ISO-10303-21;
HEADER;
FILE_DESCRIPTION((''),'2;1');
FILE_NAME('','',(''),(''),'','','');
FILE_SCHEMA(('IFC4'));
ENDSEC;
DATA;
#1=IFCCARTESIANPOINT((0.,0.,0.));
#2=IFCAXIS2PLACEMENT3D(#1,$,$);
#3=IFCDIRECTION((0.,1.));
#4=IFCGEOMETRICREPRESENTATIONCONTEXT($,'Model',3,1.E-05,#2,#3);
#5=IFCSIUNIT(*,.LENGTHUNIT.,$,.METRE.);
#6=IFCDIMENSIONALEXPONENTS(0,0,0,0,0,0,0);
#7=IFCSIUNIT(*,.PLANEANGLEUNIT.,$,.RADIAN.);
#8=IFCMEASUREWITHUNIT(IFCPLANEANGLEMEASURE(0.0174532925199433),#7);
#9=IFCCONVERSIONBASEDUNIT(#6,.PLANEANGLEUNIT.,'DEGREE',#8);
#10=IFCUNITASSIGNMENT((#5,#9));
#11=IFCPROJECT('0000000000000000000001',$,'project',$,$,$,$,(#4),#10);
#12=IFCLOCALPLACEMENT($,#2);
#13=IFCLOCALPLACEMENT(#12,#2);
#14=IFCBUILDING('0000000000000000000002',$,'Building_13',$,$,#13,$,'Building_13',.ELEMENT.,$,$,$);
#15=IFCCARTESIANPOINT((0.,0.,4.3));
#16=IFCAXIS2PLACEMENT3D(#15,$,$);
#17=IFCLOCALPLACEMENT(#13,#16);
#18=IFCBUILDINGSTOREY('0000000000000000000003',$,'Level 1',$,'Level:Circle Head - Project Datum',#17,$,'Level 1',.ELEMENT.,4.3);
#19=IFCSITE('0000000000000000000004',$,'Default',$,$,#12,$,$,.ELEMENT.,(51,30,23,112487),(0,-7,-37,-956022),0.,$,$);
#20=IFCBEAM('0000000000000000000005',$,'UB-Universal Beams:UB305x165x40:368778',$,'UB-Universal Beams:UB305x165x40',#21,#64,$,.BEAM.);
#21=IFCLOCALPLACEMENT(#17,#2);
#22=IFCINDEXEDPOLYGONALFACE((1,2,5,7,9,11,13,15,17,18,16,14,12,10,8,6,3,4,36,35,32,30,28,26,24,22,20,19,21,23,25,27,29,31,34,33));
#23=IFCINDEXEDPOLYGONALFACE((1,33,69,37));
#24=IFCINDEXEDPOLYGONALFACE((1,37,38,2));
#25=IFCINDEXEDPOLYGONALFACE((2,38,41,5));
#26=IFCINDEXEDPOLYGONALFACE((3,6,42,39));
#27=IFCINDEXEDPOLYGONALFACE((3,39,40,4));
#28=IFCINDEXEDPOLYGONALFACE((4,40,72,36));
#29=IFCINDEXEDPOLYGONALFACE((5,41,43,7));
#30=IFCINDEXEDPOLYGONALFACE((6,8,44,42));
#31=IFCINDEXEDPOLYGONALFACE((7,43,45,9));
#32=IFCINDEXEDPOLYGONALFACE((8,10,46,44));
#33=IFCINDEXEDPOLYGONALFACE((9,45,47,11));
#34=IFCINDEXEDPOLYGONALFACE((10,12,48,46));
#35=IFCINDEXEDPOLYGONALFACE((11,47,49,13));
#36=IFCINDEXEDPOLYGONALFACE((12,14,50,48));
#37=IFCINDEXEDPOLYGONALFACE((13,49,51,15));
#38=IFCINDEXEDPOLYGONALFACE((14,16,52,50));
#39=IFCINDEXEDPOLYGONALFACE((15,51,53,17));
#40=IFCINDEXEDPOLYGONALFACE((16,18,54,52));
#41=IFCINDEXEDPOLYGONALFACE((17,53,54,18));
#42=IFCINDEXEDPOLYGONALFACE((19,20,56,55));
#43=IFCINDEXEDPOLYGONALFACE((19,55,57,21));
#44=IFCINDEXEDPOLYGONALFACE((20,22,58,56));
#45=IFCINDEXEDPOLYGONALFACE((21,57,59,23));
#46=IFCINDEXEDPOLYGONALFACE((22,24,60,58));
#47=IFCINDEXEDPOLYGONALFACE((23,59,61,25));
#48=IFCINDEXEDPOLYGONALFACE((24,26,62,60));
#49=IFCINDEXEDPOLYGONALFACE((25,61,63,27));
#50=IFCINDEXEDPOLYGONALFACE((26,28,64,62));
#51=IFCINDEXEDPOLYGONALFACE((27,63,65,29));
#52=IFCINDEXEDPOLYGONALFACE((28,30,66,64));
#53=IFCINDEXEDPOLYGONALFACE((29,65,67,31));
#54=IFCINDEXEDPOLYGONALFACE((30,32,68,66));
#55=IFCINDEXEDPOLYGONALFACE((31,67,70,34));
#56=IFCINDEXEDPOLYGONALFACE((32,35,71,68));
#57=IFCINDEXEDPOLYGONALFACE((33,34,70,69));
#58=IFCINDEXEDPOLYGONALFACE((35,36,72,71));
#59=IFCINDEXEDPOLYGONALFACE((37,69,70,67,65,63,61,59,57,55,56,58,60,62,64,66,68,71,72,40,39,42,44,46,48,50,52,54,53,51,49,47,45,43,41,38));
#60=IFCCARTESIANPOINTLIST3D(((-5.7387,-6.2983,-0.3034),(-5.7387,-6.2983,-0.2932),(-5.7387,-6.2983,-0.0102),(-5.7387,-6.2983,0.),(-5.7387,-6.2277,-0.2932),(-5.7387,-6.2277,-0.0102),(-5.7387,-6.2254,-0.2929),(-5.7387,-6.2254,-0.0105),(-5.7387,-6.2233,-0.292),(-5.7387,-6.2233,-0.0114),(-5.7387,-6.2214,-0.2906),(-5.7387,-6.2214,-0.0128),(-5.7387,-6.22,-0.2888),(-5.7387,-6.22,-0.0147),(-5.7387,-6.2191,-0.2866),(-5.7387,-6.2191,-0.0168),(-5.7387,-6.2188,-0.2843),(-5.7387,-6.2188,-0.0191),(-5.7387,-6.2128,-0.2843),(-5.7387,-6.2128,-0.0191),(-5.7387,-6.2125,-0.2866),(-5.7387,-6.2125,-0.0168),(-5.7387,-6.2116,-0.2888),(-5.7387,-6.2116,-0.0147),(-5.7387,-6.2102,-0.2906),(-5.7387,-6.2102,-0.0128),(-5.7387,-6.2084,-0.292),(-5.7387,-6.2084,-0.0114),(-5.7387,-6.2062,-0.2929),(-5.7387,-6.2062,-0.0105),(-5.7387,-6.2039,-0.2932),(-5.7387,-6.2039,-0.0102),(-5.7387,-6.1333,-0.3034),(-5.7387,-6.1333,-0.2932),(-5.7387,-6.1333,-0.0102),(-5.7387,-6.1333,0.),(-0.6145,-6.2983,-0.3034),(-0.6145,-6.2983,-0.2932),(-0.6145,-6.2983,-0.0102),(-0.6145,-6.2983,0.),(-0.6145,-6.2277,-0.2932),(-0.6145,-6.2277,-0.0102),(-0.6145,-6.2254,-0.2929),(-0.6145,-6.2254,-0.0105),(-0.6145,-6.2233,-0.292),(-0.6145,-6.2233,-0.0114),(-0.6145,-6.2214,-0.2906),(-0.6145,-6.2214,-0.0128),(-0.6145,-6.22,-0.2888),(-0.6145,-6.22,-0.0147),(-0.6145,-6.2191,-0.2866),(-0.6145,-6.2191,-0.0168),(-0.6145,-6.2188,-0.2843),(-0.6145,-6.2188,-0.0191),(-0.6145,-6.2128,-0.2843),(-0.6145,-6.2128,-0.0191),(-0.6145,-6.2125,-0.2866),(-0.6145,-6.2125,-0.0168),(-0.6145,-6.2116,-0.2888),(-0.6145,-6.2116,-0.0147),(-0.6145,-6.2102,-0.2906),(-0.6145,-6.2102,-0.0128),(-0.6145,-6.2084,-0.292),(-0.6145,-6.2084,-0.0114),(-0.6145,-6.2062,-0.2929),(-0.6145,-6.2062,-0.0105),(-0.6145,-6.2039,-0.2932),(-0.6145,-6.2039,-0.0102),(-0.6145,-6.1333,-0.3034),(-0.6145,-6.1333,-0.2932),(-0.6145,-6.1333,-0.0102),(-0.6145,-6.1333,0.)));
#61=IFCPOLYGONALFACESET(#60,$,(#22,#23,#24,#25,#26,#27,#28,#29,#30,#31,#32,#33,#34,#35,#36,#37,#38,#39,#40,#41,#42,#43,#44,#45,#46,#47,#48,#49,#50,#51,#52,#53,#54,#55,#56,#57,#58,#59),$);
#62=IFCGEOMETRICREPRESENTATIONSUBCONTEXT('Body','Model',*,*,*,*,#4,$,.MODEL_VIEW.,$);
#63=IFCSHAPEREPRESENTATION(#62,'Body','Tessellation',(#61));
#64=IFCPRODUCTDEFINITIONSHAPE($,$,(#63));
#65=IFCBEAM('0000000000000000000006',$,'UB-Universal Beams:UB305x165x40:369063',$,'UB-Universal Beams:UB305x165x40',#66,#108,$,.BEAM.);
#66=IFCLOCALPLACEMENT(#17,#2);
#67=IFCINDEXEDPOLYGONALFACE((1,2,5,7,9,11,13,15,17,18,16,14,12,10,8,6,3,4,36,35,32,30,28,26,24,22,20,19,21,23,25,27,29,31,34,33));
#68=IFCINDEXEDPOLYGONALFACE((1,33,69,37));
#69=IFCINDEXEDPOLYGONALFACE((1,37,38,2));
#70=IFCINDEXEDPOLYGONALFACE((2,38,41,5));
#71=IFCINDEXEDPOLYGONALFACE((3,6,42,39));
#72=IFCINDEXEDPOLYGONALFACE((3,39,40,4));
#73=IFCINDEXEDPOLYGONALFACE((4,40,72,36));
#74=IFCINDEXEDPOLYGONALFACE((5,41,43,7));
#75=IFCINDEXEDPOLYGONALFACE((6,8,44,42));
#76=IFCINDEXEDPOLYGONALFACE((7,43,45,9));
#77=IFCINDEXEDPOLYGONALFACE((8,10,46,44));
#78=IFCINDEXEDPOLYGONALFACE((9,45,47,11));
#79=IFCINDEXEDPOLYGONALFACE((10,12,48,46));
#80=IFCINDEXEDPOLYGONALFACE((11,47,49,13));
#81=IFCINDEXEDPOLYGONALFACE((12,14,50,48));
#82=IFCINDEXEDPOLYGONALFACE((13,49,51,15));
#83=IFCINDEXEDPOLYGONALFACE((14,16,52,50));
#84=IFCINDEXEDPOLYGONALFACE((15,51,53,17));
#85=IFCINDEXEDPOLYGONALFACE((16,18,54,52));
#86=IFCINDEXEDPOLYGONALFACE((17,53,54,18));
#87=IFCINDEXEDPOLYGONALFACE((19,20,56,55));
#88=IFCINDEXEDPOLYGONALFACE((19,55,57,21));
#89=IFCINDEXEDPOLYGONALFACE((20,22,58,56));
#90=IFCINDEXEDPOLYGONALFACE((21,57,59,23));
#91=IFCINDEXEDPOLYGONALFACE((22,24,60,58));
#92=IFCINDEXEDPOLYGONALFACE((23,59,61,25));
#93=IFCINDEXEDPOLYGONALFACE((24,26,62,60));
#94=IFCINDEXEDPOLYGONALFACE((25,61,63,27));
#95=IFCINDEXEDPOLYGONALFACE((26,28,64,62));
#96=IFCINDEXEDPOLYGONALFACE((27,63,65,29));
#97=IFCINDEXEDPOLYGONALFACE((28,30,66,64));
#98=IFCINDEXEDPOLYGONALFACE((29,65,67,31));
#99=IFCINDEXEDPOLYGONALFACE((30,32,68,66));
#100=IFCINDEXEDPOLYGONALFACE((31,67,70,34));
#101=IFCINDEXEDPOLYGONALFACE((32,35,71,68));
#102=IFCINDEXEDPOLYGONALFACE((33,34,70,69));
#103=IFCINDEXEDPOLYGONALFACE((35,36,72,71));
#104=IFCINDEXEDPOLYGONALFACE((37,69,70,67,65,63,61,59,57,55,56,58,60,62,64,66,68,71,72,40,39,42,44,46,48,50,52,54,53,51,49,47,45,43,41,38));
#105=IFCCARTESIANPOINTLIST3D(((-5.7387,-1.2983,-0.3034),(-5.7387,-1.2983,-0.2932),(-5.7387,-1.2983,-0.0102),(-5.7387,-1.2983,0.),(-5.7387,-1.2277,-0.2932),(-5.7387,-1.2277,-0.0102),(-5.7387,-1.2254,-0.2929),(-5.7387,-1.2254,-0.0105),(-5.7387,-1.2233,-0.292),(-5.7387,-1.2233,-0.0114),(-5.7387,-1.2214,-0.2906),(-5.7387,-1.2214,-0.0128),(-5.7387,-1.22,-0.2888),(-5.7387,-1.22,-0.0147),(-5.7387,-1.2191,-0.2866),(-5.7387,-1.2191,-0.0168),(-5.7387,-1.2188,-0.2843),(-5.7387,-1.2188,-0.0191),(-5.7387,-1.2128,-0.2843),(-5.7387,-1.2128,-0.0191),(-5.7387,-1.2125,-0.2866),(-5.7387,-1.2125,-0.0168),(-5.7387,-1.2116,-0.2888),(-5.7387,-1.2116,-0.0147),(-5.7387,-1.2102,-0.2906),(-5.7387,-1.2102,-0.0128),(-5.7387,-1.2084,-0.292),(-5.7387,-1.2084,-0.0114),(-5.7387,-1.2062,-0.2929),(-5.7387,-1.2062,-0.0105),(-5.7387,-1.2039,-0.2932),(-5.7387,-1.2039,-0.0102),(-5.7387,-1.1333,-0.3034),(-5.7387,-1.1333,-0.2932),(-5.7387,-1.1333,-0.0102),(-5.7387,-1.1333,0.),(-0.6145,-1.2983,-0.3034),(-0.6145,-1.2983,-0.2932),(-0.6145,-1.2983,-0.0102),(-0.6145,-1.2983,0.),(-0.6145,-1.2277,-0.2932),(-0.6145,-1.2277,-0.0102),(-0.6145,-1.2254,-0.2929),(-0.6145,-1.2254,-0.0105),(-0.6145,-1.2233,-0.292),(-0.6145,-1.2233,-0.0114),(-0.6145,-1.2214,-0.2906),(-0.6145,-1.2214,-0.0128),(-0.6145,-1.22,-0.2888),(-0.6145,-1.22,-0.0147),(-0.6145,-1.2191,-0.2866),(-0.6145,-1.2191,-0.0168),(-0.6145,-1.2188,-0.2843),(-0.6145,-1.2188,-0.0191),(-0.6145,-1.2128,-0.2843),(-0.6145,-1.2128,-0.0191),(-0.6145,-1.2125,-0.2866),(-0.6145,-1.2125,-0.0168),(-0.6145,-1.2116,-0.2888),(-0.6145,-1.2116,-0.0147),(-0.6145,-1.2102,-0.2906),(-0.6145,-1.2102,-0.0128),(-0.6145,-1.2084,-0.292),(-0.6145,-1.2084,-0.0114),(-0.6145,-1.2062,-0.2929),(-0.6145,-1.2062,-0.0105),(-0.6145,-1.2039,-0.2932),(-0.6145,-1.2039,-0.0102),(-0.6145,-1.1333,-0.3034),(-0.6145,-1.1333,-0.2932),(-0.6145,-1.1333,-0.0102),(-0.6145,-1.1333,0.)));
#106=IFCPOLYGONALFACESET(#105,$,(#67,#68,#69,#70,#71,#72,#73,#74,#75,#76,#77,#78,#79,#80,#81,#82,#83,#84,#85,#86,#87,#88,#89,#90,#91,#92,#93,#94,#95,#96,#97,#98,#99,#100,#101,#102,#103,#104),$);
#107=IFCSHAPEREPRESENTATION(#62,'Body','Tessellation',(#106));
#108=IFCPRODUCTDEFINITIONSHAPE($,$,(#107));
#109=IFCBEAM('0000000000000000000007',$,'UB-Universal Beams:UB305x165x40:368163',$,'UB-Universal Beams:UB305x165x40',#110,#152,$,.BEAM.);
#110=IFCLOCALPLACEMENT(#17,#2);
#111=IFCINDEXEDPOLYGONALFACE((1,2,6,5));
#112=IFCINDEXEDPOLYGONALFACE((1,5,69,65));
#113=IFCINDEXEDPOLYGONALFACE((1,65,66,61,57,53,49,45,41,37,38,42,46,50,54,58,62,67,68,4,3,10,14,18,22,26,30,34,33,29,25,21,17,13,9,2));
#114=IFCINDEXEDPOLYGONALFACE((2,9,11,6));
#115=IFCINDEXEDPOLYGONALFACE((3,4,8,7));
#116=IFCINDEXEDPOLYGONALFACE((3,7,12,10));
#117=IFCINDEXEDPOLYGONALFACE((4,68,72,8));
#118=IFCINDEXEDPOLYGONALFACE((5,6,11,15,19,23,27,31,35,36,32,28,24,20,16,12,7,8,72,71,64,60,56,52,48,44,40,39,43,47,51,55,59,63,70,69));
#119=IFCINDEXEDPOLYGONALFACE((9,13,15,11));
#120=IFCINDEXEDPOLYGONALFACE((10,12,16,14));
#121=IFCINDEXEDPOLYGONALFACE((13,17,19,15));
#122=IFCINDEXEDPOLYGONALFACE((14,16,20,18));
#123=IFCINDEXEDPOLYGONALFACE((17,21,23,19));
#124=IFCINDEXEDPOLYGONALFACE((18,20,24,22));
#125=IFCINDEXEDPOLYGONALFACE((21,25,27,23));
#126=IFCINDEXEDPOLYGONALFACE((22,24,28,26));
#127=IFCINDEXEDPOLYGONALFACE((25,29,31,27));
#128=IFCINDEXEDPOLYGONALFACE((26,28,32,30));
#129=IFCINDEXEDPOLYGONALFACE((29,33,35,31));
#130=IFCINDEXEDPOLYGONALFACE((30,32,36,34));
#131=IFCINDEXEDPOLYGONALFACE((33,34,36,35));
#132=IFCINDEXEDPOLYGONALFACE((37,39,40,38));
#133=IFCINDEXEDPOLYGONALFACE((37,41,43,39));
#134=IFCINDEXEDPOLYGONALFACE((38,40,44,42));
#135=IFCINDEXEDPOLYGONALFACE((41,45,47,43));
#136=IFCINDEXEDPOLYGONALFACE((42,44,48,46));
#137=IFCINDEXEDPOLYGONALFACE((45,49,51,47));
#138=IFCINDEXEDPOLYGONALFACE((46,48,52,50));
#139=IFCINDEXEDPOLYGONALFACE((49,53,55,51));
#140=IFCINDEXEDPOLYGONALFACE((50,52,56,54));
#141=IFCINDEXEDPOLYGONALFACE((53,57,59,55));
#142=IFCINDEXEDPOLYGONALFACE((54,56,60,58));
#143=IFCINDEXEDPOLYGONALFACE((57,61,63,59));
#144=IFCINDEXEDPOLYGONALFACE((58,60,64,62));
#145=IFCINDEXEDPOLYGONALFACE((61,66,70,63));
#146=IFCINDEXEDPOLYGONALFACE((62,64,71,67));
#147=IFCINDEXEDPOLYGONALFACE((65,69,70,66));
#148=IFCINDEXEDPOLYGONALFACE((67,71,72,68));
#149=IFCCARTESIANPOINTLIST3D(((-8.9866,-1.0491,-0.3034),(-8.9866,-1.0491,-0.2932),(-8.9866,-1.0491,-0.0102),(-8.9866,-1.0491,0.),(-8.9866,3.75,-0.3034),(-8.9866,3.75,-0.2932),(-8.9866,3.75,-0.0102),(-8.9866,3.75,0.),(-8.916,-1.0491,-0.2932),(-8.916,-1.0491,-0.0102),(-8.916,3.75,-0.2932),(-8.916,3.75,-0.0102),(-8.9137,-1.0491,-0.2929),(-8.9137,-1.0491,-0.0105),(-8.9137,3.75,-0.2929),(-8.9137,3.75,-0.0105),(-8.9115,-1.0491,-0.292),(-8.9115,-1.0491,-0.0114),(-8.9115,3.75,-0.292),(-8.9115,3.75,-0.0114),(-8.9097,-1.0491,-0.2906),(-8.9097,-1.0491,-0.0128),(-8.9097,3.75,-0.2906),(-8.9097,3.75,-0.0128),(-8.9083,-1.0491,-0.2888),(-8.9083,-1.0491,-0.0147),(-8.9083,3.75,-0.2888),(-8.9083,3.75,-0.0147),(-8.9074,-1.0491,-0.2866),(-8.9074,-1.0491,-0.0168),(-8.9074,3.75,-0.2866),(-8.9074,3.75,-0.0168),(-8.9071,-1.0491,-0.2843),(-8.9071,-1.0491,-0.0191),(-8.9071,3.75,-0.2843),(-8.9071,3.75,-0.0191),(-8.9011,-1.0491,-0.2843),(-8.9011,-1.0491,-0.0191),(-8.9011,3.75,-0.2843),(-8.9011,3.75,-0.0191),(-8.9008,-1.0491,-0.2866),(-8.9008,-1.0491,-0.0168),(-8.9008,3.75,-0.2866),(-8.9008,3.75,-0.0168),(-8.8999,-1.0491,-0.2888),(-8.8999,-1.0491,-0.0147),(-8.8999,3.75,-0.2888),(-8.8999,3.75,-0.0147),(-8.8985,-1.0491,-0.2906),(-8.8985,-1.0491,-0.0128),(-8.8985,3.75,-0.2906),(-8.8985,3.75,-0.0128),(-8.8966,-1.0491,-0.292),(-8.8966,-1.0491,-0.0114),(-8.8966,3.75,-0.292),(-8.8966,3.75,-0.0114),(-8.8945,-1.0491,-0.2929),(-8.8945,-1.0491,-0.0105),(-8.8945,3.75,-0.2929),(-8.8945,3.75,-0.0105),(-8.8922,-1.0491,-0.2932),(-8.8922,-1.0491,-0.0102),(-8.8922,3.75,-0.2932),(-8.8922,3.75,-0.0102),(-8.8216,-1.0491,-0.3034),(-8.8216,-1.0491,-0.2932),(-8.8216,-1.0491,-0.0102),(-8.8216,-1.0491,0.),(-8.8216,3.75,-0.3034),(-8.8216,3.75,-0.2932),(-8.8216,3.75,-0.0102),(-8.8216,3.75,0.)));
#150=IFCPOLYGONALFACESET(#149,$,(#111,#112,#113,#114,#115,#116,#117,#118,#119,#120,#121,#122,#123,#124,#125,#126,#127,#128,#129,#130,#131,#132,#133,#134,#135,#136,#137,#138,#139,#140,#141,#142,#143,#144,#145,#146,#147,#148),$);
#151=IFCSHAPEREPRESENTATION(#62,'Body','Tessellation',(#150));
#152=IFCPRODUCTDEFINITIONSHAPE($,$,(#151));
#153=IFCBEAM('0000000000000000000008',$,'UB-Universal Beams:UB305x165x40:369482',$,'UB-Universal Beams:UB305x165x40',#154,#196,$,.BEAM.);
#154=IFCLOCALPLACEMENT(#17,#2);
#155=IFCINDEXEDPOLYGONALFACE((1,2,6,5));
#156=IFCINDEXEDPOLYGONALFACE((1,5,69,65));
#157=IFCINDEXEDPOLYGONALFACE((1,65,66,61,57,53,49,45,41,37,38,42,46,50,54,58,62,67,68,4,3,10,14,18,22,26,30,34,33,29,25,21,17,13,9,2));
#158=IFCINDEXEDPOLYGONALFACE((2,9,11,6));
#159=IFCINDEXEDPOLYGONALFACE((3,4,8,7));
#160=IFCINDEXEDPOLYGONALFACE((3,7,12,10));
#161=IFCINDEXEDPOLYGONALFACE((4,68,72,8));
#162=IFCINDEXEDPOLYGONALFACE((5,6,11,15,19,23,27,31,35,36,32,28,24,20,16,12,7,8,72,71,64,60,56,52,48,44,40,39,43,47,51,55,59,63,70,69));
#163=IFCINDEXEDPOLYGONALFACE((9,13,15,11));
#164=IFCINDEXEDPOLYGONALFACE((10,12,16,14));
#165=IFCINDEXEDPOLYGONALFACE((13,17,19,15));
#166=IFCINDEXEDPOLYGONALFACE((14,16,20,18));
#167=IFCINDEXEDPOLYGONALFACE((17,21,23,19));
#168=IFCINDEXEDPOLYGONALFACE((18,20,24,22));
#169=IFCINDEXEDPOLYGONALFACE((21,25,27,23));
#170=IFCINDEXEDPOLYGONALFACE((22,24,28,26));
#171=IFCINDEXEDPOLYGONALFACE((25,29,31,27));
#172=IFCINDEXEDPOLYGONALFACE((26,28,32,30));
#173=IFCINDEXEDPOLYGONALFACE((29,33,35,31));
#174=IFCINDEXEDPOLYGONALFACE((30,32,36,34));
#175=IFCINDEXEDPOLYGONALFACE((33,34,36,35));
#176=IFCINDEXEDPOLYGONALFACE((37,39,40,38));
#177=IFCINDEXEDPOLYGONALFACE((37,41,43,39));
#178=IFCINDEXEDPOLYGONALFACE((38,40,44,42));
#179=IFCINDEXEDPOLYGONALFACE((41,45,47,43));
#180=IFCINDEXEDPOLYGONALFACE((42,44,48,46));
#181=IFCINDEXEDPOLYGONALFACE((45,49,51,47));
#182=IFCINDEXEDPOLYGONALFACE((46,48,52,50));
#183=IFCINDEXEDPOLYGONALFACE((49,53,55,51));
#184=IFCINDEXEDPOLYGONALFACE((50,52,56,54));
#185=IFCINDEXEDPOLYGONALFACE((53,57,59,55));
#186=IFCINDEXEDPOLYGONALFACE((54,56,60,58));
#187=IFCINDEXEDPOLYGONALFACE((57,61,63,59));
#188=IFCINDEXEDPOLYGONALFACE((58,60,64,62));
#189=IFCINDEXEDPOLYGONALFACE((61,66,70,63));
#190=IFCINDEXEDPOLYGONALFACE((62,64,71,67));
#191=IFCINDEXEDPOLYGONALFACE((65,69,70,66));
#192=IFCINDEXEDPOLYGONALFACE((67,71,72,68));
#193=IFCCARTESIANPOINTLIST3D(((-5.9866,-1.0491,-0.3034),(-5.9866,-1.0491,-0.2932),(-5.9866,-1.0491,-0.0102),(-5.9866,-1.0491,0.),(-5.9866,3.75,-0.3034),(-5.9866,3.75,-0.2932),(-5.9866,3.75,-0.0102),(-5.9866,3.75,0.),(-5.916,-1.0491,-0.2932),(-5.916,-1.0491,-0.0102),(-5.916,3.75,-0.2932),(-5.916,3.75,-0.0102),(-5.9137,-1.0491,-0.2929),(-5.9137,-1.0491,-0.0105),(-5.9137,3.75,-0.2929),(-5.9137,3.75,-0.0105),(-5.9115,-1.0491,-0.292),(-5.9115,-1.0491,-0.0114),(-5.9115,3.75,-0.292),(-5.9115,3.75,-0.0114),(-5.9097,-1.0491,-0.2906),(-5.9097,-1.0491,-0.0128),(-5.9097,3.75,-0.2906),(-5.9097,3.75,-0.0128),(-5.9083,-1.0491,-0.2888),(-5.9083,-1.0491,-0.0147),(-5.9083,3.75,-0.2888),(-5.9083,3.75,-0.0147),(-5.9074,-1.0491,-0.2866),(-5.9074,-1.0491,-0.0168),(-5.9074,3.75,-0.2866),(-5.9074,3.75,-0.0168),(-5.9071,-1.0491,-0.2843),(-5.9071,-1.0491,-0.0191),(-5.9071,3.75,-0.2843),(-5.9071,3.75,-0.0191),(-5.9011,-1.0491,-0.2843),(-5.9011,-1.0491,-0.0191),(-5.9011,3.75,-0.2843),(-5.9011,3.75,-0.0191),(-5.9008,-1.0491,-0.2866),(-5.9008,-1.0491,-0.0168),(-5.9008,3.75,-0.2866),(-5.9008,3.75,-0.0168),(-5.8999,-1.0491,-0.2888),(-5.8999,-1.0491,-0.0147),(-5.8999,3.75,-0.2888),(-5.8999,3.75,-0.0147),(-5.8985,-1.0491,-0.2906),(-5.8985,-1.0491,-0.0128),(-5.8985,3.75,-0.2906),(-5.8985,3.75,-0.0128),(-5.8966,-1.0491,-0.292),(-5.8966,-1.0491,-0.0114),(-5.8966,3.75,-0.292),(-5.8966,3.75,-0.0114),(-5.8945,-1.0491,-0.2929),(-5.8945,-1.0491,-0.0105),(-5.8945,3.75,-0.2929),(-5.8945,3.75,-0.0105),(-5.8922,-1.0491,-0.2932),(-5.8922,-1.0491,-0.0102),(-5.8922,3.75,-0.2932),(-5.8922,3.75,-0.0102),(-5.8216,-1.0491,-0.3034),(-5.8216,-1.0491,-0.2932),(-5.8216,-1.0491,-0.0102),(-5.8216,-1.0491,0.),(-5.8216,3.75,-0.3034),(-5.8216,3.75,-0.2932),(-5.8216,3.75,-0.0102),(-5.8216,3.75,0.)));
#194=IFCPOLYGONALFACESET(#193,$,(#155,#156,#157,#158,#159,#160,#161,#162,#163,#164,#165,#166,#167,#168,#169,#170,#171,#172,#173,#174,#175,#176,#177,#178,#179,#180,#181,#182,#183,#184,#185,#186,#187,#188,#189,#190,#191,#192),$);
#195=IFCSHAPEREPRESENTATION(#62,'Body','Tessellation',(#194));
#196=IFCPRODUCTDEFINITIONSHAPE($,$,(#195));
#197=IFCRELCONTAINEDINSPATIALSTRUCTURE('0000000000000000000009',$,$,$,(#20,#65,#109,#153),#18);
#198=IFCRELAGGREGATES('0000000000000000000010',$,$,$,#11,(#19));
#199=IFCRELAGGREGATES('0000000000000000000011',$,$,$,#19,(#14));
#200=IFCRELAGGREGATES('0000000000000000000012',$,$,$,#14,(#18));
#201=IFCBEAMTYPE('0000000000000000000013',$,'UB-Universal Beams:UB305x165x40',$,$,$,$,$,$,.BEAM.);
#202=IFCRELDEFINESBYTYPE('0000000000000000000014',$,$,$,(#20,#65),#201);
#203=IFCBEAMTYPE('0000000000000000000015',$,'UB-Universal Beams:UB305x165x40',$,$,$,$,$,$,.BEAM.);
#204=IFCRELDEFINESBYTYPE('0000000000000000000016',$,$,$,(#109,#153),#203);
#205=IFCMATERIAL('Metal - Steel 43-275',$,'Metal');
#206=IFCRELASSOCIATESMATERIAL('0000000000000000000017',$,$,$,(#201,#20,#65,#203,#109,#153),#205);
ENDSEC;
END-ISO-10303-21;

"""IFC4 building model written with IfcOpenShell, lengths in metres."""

from ifc_helpers import new_model, entity, si_unit, converted_unit, direction, frame, origin, place, context, subcontext, project, spatial, line, arc, indexed_curve, outline, extrude, source, transform, mapped, material, type_object, type_shapes, element, save


model = new_model("IFC4")

# Units and contexts
model_context = context("Model", 3, precision=1e-05, world=origin(), true_north=direction((0.0, 1.0)))
body_context = subcontext(model_context, "Body", "Model", "MODEL_VIEW")
ifc_project = project(units=[si_unit("LENGTHUNIT", "METRE"), converted_unit("PLANEANGLEUNIT", "DEGREE", entity("IfcPlaneAngleMeasure", 0.0174532925199433), si_unit("PLANEANGLEUNIT", "RADIAN"), dimensions=[0, 0, 0, 0, 0, 0, 0])], contexts=[model_context])

# Site, building, storey
site_placement = place(None, origin())
site = spatial("IfcSite", under=ifc_project, at=site_placement, Name="Default", CompositionType="ELEMENT", RefLatitude=(51, 30, 23, 112487), RefLongitude=(0, -7, -37, -956022), RefElevation=0.0)
building_placement = place(site_placement, origin())
building = spatial("IfcBuilding", under=site, at=building_placement, Name="Building_13", LongName="Building_13", CompositionType="ELEMENT")
storey_placement = place(building_placement, frame((0.0, 0.0, 4.3)))
storey = spatial("IfcBuildingStorey", under=building, at=storey_placement, Name="Level 1", ObjectType="Level:Circle Head - Project Datum", LongName="Level 1", CompositionType="ELEMENT", Elevation=4.3)

# Beams
ifc_material_1 = material(Name="Metal - Steel 43-275", Category="Metal")
beam_type_1 = type_object("IfcBeamType", Name="UB-Universal Beams:UB305x165x40", PredefinedType="BEAM", material=ifc_material_1)
shared_shape_1 = source(origin(), body_context, "Body", "SweptSolid", [
    extrude(outline(indexed_curve([(-0.0825, -0.1415), (-0.0825, -0.1517), (0.0825, -0.1517), (0.0825, -0.1415), (0.0119, -0.1415), (0.0056, -0.1389), (0.003, -0.1326), (0.003, 0.1326), (0.0056, 0.1389), (0.0119, 0.1415), (0.0825, 0.1415), (0.0825, 0.1517), (-0.0825, 0.1517), (-0.0825, 0.1415), (-0.0119, 0.1415), (-0.0056, 0.1389), (-0.003, 0.1326), (-0.003, -0.1326), (-0.0056, -0.1389), (-0.0119, -0.1415)], segments=[line(1, 2, 3, 4, 5), arc(5, 6, 7), line(7, 8), arc(8, 9, 10), line(10, 11, 12, 13, 14, 15), arc(15, 16, 17), line(17, 18), arc(18, 19, 20), line(20, 1)], self_intersect=False)), frame((-2.5621, 0.0, 0.0), z_axis=(-1.0, 0.0, 0.0), x_axis=(0.0, -1.0, 0.0)), (0.0, 0.0, -1.0), 5.1242),
])
type_shapes(beam_type_1, [shared_shape_1])
for number, where, name in (
    (1, (-3.1766, -6.2158, -0.1517), "UB-Universal Beams:UB305x165x40:368778"),
    (2, (-3.1766, -1.2158, -0.1517), "UB-Universal Beams:UB305x165x40:369063"),
):
    element("IfcBeam", number, at=place(storey_placement, frame(where)), inside=storey, type_object=beam_type_1, material=ifc_material_1, Name=name, ObjectType="UB-Universal Beams:UB305x165x40", PredefinedType="BEAM", context=body_context, shape_type="MappedRepresentation", body=[
        mapped(shared_shape_1, transform((0.0, 0.0, 0.0), scale=1.0)),
    ])
beam_type_2 = type_object("IfcBeamType", Name="UB-Universal Beams:UB305x165x40", PredefinedType="BEAM", material=ifc_material_1)
shared_shape_2 = source(origin(), body_context, "Body", "SweptSolid", [
    extrude(outline(indexed_curve([(-0.0825, -0.1415), (-0.0825, -0.1517), (0.0825, -0.1517), (0.0825, -0.1415), (0.0119, -0.1415), (0.0056, -0.1389), (0.003, -0.1326), (0.003, 0.1326), (0.0056, 0.1389), (0.0119, 0.1415), (0.0825, 0.1415), (0.0825, 0.1517), (-0.0825, 0.1517), (-0.0825, 0.1415), (-0.0119, 0.1415), (-0.0056, 0.1389), (-0.003, 0.1326), (-0.003, -0.1326), (-0.0056, -0.1389), (-0.0119, -0.1415)], segments=[line(1, 2, 3, 4, 5), arc(5, 6, 7), line(7, 8), arc(8, 9, 10), line(10, 11, 12, 13, 14, 15), arc(15, 16, 17), line(17, 18), arc(18, 19, 20), line(20, 1)], self_intersect=False)), frame((-2.3996, 0.0, 0.0), z_axis=(-1.0, 0.0, 0.0), x_axis=(0.0, -1.0, 0.0)), (0.0, 0.0, -1.0), 4.7991),
])
type_shapes(beam_type_2, [shared_shape_2])
for number, where, z_axis, x_axis, name in (
    (3, (-8.9041, 1.3504, -0.1517), (0.0, 0.0, 1.0), (0.0, -1.0, 0.0), "UB-Universal Beams:UB305x165x40:368163"),
    (4, (-5.9041, 1.3504, -0.1517), (0.0, 0.0, 1.0), (0.0, 1.0, 0.0), "UB-Universal Beams:UB305x165x40:369482"),
):
    element("IfcBeam", number, at=place(storey_placement, frame(where, z_axis=z_axis, x_axis=x_axis)), inside=storey, type_object=beam_type_2, material=ifc_material_1, Name=name, ObjectType="UB-Universal Beams:UB305x165x40", PredefinedType="BEAM", context=body_context, shape_type="MappedRepresentation", body=[
        mapped(shared_shape_2, transform((0.0, 0.0, 0.0), scale=1.0)),
    ])

save(model, "model.ifc")
